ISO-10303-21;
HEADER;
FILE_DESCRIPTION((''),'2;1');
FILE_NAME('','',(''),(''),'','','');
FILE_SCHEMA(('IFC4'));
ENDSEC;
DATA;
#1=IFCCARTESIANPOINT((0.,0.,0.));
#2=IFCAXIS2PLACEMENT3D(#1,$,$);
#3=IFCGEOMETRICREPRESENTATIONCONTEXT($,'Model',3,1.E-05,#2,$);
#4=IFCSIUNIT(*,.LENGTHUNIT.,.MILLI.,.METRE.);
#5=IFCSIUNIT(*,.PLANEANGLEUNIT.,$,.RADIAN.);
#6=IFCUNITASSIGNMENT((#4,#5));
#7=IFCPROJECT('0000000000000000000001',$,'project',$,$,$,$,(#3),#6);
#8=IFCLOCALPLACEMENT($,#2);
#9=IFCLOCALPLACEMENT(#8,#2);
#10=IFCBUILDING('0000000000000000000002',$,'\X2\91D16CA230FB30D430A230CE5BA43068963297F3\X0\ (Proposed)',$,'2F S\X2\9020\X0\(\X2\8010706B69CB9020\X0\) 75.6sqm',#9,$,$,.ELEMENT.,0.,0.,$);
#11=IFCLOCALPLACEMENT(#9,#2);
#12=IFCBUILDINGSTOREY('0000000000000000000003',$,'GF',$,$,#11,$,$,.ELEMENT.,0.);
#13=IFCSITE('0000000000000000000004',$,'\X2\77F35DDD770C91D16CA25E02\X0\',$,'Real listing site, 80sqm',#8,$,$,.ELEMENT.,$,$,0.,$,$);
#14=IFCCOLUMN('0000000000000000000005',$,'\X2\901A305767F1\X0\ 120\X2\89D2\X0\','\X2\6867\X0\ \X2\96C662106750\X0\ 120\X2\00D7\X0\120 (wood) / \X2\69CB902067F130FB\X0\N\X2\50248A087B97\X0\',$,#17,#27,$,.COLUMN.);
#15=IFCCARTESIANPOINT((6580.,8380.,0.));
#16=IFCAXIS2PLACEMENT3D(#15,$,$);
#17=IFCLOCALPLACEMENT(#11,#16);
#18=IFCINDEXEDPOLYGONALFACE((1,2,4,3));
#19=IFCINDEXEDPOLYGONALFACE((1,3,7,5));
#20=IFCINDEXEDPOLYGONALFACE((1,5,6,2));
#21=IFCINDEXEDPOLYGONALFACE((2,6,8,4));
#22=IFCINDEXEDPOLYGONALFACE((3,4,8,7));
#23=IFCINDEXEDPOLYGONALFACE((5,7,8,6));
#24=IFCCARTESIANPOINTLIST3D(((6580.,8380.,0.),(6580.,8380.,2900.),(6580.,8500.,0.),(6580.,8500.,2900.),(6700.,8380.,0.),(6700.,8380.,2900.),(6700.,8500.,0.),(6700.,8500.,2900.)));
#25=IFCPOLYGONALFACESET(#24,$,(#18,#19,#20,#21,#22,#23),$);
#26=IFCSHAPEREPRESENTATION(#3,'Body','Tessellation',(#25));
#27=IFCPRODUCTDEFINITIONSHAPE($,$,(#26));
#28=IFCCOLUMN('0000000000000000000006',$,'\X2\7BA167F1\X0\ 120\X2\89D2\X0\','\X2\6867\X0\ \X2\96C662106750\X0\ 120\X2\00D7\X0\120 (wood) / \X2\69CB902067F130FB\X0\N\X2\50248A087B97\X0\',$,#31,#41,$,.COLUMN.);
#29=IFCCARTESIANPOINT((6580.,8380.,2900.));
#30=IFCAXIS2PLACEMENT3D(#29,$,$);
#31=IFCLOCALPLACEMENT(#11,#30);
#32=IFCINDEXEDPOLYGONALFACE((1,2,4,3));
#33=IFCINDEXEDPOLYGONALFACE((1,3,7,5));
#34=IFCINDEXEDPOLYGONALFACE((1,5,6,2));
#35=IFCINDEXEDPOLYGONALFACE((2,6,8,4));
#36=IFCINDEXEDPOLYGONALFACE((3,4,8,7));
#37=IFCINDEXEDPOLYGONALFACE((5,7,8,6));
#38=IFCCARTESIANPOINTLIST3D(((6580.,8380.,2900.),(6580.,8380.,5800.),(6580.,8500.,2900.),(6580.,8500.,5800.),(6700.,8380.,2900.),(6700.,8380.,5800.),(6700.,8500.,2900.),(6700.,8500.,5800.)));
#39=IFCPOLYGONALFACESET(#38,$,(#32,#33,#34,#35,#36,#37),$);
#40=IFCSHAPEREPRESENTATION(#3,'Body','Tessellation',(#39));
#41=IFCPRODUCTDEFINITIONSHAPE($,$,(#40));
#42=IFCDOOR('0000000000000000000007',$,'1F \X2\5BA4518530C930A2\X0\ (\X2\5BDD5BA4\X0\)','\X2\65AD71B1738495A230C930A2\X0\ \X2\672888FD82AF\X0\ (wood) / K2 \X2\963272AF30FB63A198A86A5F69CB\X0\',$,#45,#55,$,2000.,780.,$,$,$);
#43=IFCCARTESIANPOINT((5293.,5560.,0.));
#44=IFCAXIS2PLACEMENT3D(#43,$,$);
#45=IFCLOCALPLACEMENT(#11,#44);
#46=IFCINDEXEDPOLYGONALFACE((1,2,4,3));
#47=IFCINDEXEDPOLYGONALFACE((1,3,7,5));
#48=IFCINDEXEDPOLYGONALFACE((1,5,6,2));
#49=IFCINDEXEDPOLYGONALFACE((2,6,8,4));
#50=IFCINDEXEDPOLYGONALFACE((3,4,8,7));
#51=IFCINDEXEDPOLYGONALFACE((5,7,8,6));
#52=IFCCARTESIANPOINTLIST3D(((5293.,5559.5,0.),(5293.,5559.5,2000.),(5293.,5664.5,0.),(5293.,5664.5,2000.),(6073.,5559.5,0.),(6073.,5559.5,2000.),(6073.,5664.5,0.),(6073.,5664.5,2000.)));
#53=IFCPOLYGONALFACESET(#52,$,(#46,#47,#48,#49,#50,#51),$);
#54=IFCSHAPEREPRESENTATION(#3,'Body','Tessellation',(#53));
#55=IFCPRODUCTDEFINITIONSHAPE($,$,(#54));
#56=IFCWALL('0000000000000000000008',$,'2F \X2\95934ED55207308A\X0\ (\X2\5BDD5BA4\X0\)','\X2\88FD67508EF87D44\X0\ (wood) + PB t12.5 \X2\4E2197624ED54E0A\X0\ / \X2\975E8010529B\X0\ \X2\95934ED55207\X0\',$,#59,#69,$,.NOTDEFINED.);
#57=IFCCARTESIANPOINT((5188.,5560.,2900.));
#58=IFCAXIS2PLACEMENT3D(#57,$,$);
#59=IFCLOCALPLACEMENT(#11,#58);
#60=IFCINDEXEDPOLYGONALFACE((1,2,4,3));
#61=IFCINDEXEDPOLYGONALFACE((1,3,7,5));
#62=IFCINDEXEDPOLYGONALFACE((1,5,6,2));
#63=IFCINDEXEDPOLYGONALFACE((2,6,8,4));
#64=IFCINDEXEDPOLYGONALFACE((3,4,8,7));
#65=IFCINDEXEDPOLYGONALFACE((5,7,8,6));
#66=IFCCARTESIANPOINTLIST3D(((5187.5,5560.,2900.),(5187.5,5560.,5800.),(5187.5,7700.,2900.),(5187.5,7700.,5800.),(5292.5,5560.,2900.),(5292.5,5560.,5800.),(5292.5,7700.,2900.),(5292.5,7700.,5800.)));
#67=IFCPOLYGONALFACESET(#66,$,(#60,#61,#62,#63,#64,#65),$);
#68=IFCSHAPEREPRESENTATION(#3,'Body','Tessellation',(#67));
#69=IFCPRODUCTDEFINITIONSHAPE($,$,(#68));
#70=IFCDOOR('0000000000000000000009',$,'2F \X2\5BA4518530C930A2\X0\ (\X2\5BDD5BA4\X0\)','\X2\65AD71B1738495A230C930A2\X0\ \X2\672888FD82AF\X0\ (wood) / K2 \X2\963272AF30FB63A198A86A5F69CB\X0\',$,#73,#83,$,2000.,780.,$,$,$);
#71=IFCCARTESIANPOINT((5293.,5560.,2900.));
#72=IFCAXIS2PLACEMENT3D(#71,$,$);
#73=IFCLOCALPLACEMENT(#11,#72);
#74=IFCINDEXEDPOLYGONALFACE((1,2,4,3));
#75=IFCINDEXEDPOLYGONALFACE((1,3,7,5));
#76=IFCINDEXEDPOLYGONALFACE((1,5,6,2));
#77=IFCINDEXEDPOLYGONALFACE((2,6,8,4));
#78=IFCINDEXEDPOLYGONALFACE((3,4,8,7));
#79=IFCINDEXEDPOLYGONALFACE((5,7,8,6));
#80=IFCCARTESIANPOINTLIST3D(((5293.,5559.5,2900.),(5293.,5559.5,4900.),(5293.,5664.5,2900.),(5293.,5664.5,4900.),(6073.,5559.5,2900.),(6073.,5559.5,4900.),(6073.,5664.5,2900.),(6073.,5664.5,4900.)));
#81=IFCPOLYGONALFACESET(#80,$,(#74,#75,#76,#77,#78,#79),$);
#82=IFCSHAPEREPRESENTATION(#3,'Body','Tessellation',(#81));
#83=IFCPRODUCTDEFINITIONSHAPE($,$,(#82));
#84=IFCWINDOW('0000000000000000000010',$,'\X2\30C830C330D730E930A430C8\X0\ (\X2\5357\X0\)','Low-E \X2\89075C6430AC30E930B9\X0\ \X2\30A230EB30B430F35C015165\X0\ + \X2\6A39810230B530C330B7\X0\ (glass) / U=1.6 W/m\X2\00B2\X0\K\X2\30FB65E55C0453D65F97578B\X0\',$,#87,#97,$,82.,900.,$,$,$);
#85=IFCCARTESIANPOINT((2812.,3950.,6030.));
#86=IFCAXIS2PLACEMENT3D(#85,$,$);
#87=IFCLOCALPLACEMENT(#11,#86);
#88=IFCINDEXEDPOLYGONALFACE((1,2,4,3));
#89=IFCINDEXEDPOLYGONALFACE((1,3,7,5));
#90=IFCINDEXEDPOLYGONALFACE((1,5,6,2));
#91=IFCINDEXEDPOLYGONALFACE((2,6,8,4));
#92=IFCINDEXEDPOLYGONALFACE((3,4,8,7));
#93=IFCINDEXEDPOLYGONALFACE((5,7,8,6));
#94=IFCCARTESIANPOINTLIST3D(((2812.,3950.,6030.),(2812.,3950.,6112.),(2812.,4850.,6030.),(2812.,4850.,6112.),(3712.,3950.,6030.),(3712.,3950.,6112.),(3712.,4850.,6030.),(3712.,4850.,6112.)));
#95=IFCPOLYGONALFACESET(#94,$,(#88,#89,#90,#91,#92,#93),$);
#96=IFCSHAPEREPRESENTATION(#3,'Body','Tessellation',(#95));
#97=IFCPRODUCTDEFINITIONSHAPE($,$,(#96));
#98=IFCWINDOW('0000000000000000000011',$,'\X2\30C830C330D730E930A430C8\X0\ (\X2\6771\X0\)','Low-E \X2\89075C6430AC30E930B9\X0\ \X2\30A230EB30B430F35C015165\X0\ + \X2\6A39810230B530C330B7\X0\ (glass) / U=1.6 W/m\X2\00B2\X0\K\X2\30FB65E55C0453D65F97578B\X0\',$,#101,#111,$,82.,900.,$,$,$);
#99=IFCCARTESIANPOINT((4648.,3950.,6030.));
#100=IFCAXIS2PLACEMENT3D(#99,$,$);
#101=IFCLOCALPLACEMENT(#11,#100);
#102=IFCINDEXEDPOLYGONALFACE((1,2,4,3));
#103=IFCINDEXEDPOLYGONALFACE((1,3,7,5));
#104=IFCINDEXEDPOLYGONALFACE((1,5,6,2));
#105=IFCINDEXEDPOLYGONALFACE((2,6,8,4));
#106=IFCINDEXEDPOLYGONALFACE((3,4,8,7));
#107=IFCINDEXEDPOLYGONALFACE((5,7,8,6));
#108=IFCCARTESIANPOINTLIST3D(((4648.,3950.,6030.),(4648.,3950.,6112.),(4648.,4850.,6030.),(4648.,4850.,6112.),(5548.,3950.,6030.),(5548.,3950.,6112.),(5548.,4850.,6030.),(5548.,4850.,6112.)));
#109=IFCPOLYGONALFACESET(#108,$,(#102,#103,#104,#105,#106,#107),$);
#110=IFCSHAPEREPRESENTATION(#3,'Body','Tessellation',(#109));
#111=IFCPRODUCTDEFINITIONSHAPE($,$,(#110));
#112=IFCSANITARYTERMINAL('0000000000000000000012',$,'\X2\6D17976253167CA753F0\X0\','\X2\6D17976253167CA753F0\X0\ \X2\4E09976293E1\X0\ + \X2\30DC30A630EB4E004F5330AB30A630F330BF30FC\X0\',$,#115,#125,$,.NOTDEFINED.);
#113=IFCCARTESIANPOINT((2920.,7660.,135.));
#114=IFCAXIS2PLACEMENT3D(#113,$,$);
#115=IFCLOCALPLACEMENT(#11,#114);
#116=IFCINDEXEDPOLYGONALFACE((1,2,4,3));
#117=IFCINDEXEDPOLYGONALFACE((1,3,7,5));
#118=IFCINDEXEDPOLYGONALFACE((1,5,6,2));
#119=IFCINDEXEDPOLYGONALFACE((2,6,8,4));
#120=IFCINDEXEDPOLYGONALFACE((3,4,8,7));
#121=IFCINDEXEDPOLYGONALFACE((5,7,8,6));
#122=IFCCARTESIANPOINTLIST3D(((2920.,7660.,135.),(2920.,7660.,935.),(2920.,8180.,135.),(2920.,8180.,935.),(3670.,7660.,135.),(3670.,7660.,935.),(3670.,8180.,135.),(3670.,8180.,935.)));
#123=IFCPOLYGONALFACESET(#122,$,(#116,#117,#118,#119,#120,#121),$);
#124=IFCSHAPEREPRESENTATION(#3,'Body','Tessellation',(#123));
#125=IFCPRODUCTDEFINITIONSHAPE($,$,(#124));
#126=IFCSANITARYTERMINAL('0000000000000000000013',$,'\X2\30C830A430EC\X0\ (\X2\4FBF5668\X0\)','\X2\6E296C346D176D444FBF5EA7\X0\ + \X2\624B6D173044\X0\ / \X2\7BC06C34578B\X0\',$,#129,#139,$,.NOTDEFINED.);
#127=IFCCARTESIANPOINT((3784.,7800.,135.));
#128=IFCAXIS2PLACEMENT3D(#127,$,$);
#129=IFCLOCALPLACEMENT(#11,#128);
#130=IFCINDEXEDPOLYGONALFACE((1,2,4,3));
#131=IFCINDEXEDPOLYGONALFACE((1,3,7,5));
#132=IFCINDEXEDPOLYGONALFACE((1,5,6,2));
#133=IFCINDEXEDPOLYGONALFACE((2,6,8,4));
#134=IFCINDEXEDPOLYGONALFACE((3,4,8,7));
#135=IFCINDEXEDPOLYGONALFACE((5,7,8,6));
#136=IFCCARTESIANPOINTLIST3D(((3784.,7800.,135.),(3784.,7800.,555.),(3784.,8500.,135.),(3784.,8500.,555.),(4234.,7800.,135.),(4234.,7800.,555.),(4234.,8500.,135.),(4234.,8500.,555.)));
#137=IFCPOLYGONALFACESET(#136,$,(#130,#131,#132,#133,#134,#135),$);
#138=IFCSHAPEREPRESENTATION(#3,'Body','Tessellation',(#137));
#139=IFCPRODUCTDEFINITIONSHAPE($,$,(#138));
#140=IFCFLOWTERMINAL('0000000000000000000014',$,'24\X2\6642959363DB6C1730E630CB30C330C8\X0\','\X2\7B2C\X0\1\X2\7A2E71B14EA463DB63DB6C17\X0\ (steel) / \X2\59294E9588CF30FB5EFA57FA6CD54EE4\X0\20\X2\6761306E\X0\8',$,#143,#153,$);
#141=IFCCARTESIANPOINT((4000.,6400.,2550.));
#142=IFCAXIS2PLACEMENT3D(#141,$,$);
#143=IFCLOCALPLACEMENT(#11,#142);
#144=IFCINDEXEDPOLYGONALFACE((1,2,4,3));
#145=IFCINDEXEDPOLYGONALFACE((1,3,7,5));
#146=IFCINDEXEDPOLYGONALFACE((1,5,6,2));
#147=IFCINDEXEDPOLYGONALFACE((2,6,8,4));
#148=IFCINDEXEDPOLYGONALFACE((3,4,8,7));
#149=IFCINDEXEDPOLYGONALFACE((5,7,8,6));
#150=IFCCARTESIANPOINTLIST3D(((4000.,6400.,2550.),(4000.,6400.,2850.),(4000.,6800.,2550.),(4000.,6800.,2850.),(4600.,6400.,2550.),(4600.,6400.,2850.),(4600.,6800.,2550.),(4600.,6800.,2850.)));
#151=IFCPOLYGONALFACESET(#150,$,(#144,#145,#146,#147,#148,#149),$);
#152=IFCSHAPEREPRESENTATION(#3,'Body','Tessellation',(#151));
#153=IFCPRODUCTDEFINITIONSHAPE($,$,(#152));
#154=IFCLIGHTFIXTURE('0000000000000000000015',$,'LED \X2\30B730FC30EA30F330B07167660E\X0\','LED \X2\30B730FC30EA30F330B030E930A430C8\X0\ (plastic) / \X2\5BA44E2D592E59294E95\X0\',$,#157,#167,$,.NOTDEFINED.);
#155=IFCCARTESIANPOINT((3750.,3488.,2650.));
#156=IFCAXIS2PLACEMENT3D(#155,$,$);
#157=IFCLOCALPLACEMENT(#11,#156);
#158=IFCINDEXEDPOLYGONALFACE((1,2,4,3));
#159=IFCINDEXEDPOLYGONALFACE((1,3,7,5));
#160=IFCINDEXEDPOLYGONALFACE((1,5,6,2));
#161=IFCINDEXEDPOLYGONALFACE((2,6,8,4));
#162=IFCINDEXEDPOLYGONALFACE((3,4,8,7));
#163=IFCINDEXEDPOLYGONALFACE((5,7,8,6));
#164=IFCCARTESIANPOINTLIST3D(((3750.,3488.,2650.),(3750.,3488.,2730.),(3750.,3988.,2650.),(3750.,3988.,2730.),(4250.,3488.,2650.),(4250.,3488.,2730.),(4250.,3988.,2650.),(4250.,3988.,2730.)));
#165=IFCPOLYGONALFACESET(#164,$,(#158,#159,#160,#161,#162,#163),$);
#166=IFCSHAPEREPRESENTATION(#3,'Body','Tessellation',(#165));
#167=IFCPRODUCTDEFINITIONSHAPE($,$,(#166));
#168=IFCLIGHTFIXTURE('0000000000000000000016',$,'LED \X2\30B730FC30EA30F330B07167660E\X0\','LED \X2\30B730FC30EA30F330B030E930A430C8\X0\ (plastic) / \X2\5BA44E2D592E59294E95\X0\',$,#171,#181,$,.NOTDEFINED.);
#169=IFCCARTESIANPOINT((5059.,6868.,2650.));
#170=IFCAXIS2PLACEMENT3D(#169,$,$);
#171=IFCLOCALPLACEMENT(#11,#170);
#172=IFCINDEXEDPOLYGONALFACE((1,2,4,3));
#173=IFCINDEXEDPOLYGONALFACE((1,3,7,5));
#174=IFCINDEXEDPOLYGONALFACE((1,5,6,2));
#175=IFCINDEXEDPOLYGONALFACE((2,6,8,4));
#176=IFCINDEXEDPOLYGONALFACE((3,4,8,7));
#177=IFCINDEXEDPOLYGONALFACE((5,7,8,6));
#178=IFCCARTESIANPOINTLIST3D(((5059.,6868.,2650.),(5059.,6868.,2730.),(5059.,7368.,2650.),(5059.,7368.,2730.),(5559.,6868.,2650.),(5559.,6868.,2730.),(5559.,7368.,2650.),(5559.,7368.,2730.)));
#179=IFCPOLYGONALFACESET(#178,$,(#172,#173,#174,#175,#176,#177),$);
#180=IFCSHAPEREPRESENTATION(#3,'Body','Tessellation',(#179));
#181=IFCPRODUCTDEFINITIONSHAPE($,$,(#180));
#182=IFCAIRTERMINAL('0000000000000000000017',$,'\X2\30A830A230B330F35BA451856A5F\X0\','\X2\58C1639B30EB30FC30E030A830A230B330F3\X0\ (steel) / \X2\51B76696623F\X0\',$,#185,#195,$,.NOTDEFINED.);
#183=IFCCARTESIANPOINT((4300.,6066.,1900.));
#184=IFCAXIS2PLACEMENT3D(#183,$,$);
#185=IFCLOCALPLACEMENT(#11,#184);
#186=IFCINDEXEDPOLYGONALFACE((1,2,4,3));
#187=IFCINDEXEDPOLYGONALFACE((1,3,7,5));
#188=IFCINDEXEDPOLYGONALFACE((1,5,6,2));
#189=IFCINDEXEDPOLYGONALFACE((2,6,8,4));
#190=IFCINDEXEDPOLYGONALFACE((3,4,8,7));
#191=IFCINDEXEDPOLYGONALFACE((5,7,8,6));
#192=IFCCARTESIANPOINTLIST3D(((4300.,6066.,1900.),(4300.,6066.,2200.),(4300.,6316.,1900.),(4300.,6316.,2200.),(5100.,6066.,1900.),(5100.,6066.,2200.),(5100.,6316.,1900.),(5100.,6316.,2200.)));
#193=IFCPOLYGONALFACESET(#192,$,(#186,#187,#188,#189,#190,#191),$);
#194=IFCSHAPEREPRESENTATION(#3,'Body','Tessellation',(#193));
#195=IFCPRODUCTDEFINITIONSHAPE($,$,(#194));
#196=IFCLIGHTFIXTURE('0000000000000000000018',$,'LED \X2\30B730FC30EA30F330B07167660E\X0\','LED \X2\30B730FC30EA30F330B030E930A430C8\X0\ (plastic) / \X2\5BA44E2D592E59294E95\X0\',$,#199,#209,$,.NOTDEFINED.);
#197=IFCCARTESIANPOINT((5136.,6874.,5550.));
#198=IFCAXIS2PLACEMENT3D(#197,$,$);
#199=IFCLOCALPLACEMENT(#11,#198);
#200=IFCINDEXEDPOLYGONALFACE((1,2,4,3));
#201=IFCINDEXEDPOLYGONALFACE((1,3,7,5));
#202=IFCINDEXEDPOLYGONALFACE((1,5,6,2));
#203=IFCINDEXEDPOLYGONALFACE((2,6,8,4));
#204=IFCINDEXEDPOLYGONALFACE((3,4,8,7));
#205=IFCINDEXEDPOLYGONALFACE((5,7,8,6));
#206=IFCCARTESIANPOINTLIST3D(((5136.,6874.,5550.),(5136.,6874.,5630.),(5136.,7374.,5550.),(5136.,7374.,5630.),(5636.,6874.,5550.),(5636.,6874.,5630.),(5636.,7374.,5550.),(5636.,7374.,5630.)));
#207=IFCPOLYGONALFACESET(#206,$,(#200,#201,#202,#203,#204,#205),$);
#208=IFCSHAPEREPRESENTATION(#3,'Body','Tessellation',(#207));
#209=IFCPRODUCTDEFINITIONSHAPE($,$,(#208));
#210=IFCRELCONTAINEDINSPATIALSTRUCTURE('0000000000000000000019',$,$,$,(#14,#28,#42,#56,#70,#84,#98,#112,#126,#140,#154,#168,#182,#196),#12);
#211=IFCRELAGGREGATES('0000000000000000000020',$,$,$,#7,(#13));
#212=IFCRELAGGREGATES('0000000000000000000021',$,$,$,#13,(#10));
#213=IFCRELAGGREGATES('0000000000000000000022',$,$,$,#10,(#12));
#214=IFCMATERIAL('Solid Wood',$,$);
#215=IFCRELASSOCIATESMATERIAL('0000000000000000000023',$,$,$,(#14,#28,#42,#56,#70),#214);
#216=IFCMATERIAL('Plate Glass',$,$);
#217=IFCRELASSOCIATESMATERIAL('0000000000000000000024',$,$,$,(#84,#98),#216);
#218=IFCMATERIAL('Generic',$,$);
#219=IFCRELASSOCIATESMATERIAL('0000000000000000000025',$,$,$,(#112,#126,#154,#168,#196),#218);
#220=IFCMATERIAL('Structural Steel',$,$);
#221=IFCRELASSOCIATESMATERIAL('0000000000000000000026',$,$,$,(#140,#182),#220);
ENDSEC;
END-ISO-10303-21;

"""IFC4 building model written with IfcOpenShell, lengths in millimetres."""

from ifc_helpers import new_model, si_unit, frame, frame_2d, origin, place, context, project, spatial, rectangle, extrude, material, element, save


model = new_model("IFC4")

# Units and contexts
model_context = context("Model", 3, precision=1e-05, world=origin())
ifc_project = project(units=[si_unit("LENGTHUNIT", "METRE", prefix="MILLI"), si_unit("PLANEANGLEUNIT", "RADIAN")], contexts=[model_context])

# Site, building, storey
site_placement = place(None, origin())
site = spatial("IfcSite", under=ifc_project, at=site_placement, Name="石川県金沢市", ObjectType="Real listing site, 80sqm", CompositionType="ELEMENT", RefElevation=0.0)
building_placement = place(site_placement, origin())
building = spatial("IfcBuilding", under=site, at=building_placement, Name="金沢・ピアノ室と防音 (Proposed)", ObjectType="2F S造(耐火構造) 75.6sqm", CompositionType="ELEMENT", ElevationOfRefHeight=0.0, ElevationOfTerrain=0.0)
storey_placement = place(building_placement, origin())
storey = spatial("IfcBuildingStorey", under=building, at=storey_placement, Name="GF", CompositionType="ELEMENT", Elevation=0.0)

# Columns
ifc_material_1 = material(Name="Solid Wood")
column_1_placement = place(storey_placement, frame((6580.0, 8380.0, 0.0)))
element("IfcColumn", 1, at=column_1_placement, inside=storey, material=ifc_material_1, Name="通し柱 120角", Description="桧 集成材 120×120 (wood) / 構造柱・N値計算", PredefinedType="COLUMN", context=model_context, shape_type="SweptSolid", body=[
    extrude(rectangle(XDim=120.0, YDim=120.0, at=frame_2d((60.0, 60.0))), frame((6580.0, 8380.0, 0.0)), (0.0, 0.0, 1.0), 2900.0),
])
column_2_placement = place(storey_placement, frame((6580.0, 8380.0, 2900.0)))
element("IfcColumn", 2, at=column_2_placement, inside=storey, material=ifc_material_1, Name="管柱 120角", Description="桧 集成材 120×120 (wood) / 構造柱・N値計算", PredefinedType="COLUMN", context=model_context, shape_type="SweptSolid", body=[
    extrude(rectangle(XDim=120.0, YDim=120.0, at=frame_2d((60.0, 60.0))), frame((6580.0, 8380.0, 2900.0)), (0.0, 0.0, 1.0), 2900.0),
])

# Door
door_1_placement = place(storey_placement, frame((5293.0, 5560.0, 0.0)))
element("IfcDoor", 3, at=door_1_placement, inside=storey, material=ifc_material_1, Name="1F 室内ドア (寝室)", Description="断熱玄関ドア 木製芯 (wood) / K2 防犯・採風機構", OverallHeight=2000.0, OverallWidth=780.0, context=model_context, shape_type="SweptSolid", body=[
    extrude(rectangle(XDim=780.0, YDim=105.0, at=frame_2d((390.0, 52.0))), frame((5293.0, 5560.0, 0.0)), (0.0, 0.0, 1.0), 2000.0),
])

# Wall
wall_1_placement = place(storey_placement, frame((5188.0, 5560.0, 2900.0)))
element("IfcWall", 4, at=wall_1_placement, inside=storey, material=ifc_material_1, Name="2F 間仕切り (寝室)", Description="製材軸組 (wood) + PB t12.5 両面仕上 / 非耐力 間仕切", PredefinedType="NOTDEFINED", context=model_context, shape_type="SweptSolid", body=[
    extrude(rectangle(XDim=105.0, YDim=2140.0, at=frame_2d((52.0, 1070.0))), frame((5188.0, 5560.0, 2900.0)), (0.0, 0.0, 1.0), 2900.0),
])

# Door
door_2_placement = place(storey_placement, frame((5293.0, 5560.0, 2900.0)))
element("IfcDoor", 5, at=door_2_placement, inside=storey, material=ifc_material_1, Name="2F 室内ドア (寝室)", Description="断熱玄関ドア 木製芯 (wood) / K2 防犯・採風機構", OverallHeight=2000.0, OverallWidth=780.0, context=model_context, shape_type="SweptSolid", body=[
    extrude(rectangle(XDim=780.0, YDim=105.0, at=frame_2d((390.0, 52.0))), frame((5293.0, 5560.0, 2900.0)), (0.0, 0.0, 1.0), 2000.0),
])

# Windows
ifc_material_2 = material(Name="Plate Glass")
window_1_placement = place(storey_placement, frame((2812.0, 3950.0, 6030.0)))
element("IfcWindow", 6, at=window_1_placement, inside=storey, material=ifc_material_2, Name="トップライト (南)", Description="Low-E 複層ガラス アルゴン封入 + 樹脂サッシ (glass) / U=1.6 W/m²K・日射取得型", OverallHeight=82.0, OverallWidth=900.0, context=model_context, shape_type="SweptSolid", body=[
    extrude(rectangle(XDim=900.0, YDim=900.0, at=frame_2d((450.0, 450.0))), frame((2812.0, 3950.0, 6030.0)), (0.0, 0.0, 1.0), 82.0),
])
window_2_placement = place(storey_placement, frame((4648.0, 3950.0, 6030.0)))
element("IfcWindow", 7, at=window_2_placement, inside=storey, material=ifc_material_2, Name="トップライト (東)", Description="Low-E 複層ガラス アルゴン封入 + 樹脂サッシ (glass) / U=1.6 W/m²K・日射取得型", OverallHeight=82.0, OverallWidth=900.0, context=model_context, shape_type="SweptSolid", body=[
    extrude(rectangle(XDim=900.0, YDim=900.0, at=frame_2d((450.0, 450.0))), frame((4648.0, 3950.0, 6030.0)), (0.0, 0.0, 1.0), 82.0),
])

# Sanitary terminals
ifc_material_3 = material(Name="Generic")
sanitary_terminal_1_placement = place(storey_placement, frame((2920.0, 7660.0, 135.0)))
element("IfcSanitaryTerminal", 8, at=sanitary_terminal_1_placement, inside=storey, material=ifc_material_3, Name="洗面化粧台", Description="洗面化粧台 三面鏡 + ボウル一体カウンター", PredefinedType="NOTDEFINED", context=model_context, shape_type="SweptSolid", body=[
    extrude(rectangle(XDim=750.0, YDim=520.0, at=frame_2d((375.0, 260.0))), frame((2920.0, 7660.0, 135.0)), (0.0, 0.0, 1.0), 800.0),
])
sanitary_terminal_2_placement = place(storey_placement, frame((3784.0, 7800.0, 135.0)))
element("IfcSanitaryTerminal", 9, at=sanitary_terminal_2_placement, inside=storey, material=ifc_material_3, Name="トイレ (便器)", Description="温水洗浄便座 + 手洗い / 節水型", PredefinedType="NOTDEFINED", context=model_context, shape_type="SweptSolid", body=[
    extrude(rectangle(XDim=450.0, YDim=700.0, at=frame_2d((225.0, 350.0))), frame((3784.0, 7800.0, 135.0)), (0.0, 0.0, 1.0), 420.0),
])

# Flow terminal
ifc_material_4 = material(Name="Structural Steel")
flow_terminal_placement = place(storey_placement, frame((4000.0, 6400.0, 2550.0)))
element("IfcFlowTerminal", 10, at=flow_terminal_placement, inside=storey, material=ifc_material_4, Name="24時間換気ユニット", Description="第1種熱交換換気 (steel) / 天井裏・建基法令20条の8", context=model_context, shape_type="SweptSolid", body=[
    extrude(rectangle(XDim=600.0, YDim=400.0, at=frame_2d((300.0, 200.0))), frame((4000.0, 6400.0, 2550.0)), (0.0, 0.0, 1.0), 300.0),
])

# Light fixtures
light_fixture_1_placement = place(storey_placement, frame((3750.0, 3488.0, 2650.0)))
element("IfcLightFixture", 11, at=light_fixture_1_placement, inside=storey, material=ifc_material_3, Name="LED シーリング照明", Description="LED シーリングライト (plastic) / 室中央天井", PredefinedType="NOTDEFINED", context=model_context, shape_type="SweptSolid", body=[
    extrude(rectangle(XDim=500.0, YDim=500.0, at=frame_2d((250.0, 250.0))), frame((3750.0, 3488.0, 2650.0)), (0.0, 0.0, 1.0), 80.0),
])
light_fixture_2_placement = place(storey_placement, frame((5059.0, 6868.0, 2650.0)))
element("IfcLightFixture", 12, at=light_fixture_2_placement, inside=storey, material=ifc_material_3, Name="LED シーリング照明", Description="LED シーリングライト (plastic) / 室中央天井", PredefinedType="NOTDEFINED", context=model_context, shape_type="SweptSolid", body=[
    extrude(rectangle(XDim=500.0, YDim=500.0, at=frame_2d((250.0, 250.0))), frame((5059.0, 6868.0, 2650.0)), (0.0, 0.0, 1.0), 80.0),
])

# Air terminal
air_terminal_placement = place(storey_placement, frame((4300.0, 6066.0, 1900.0)))
element("IfcAirTerminal", 13, at=air_terminal_placement, inside=storey, material=ifc_material_4, Name="エアコン室内機", Description="壁掛ルームエアコン (steel) / 冷暖房", PredefinedType="NOTDEFINED", context=model_context, shape_type="SweptSolid", body=[
    extrude(rectangle(XDim=800.0, YDim=250.0, at=frame_2d((400.0, 125.0))), frame((4300.0, 6066.0, 1900.0)), (0.0, 0.0, 1.0), 300.0),
])

# Light fixture
light_fixture_3_placement = place(storey_placement, frame((5136.0, 6874.0, 5550.0)))
element("IfcLightFixture", 14, at=light_fixture_3_placement, inside=storey, material=ifc_material_3, Name="LED シーリング照明", Description="LED シーリングライト (plastic) / 室中央天井", PredefinedType="NOTDEFINED", context=model_context, shape_type="SweptSolid", body=[
    extrude(rectangle(XDim=500.0, YDim=500.0, at=frame_2d((250.0, 250.0))), frame((5136.0, 6874.0, 5550.0)), (0.0, 0.0, 1.0), 80.0),
])

save(model, "model.ifc")
